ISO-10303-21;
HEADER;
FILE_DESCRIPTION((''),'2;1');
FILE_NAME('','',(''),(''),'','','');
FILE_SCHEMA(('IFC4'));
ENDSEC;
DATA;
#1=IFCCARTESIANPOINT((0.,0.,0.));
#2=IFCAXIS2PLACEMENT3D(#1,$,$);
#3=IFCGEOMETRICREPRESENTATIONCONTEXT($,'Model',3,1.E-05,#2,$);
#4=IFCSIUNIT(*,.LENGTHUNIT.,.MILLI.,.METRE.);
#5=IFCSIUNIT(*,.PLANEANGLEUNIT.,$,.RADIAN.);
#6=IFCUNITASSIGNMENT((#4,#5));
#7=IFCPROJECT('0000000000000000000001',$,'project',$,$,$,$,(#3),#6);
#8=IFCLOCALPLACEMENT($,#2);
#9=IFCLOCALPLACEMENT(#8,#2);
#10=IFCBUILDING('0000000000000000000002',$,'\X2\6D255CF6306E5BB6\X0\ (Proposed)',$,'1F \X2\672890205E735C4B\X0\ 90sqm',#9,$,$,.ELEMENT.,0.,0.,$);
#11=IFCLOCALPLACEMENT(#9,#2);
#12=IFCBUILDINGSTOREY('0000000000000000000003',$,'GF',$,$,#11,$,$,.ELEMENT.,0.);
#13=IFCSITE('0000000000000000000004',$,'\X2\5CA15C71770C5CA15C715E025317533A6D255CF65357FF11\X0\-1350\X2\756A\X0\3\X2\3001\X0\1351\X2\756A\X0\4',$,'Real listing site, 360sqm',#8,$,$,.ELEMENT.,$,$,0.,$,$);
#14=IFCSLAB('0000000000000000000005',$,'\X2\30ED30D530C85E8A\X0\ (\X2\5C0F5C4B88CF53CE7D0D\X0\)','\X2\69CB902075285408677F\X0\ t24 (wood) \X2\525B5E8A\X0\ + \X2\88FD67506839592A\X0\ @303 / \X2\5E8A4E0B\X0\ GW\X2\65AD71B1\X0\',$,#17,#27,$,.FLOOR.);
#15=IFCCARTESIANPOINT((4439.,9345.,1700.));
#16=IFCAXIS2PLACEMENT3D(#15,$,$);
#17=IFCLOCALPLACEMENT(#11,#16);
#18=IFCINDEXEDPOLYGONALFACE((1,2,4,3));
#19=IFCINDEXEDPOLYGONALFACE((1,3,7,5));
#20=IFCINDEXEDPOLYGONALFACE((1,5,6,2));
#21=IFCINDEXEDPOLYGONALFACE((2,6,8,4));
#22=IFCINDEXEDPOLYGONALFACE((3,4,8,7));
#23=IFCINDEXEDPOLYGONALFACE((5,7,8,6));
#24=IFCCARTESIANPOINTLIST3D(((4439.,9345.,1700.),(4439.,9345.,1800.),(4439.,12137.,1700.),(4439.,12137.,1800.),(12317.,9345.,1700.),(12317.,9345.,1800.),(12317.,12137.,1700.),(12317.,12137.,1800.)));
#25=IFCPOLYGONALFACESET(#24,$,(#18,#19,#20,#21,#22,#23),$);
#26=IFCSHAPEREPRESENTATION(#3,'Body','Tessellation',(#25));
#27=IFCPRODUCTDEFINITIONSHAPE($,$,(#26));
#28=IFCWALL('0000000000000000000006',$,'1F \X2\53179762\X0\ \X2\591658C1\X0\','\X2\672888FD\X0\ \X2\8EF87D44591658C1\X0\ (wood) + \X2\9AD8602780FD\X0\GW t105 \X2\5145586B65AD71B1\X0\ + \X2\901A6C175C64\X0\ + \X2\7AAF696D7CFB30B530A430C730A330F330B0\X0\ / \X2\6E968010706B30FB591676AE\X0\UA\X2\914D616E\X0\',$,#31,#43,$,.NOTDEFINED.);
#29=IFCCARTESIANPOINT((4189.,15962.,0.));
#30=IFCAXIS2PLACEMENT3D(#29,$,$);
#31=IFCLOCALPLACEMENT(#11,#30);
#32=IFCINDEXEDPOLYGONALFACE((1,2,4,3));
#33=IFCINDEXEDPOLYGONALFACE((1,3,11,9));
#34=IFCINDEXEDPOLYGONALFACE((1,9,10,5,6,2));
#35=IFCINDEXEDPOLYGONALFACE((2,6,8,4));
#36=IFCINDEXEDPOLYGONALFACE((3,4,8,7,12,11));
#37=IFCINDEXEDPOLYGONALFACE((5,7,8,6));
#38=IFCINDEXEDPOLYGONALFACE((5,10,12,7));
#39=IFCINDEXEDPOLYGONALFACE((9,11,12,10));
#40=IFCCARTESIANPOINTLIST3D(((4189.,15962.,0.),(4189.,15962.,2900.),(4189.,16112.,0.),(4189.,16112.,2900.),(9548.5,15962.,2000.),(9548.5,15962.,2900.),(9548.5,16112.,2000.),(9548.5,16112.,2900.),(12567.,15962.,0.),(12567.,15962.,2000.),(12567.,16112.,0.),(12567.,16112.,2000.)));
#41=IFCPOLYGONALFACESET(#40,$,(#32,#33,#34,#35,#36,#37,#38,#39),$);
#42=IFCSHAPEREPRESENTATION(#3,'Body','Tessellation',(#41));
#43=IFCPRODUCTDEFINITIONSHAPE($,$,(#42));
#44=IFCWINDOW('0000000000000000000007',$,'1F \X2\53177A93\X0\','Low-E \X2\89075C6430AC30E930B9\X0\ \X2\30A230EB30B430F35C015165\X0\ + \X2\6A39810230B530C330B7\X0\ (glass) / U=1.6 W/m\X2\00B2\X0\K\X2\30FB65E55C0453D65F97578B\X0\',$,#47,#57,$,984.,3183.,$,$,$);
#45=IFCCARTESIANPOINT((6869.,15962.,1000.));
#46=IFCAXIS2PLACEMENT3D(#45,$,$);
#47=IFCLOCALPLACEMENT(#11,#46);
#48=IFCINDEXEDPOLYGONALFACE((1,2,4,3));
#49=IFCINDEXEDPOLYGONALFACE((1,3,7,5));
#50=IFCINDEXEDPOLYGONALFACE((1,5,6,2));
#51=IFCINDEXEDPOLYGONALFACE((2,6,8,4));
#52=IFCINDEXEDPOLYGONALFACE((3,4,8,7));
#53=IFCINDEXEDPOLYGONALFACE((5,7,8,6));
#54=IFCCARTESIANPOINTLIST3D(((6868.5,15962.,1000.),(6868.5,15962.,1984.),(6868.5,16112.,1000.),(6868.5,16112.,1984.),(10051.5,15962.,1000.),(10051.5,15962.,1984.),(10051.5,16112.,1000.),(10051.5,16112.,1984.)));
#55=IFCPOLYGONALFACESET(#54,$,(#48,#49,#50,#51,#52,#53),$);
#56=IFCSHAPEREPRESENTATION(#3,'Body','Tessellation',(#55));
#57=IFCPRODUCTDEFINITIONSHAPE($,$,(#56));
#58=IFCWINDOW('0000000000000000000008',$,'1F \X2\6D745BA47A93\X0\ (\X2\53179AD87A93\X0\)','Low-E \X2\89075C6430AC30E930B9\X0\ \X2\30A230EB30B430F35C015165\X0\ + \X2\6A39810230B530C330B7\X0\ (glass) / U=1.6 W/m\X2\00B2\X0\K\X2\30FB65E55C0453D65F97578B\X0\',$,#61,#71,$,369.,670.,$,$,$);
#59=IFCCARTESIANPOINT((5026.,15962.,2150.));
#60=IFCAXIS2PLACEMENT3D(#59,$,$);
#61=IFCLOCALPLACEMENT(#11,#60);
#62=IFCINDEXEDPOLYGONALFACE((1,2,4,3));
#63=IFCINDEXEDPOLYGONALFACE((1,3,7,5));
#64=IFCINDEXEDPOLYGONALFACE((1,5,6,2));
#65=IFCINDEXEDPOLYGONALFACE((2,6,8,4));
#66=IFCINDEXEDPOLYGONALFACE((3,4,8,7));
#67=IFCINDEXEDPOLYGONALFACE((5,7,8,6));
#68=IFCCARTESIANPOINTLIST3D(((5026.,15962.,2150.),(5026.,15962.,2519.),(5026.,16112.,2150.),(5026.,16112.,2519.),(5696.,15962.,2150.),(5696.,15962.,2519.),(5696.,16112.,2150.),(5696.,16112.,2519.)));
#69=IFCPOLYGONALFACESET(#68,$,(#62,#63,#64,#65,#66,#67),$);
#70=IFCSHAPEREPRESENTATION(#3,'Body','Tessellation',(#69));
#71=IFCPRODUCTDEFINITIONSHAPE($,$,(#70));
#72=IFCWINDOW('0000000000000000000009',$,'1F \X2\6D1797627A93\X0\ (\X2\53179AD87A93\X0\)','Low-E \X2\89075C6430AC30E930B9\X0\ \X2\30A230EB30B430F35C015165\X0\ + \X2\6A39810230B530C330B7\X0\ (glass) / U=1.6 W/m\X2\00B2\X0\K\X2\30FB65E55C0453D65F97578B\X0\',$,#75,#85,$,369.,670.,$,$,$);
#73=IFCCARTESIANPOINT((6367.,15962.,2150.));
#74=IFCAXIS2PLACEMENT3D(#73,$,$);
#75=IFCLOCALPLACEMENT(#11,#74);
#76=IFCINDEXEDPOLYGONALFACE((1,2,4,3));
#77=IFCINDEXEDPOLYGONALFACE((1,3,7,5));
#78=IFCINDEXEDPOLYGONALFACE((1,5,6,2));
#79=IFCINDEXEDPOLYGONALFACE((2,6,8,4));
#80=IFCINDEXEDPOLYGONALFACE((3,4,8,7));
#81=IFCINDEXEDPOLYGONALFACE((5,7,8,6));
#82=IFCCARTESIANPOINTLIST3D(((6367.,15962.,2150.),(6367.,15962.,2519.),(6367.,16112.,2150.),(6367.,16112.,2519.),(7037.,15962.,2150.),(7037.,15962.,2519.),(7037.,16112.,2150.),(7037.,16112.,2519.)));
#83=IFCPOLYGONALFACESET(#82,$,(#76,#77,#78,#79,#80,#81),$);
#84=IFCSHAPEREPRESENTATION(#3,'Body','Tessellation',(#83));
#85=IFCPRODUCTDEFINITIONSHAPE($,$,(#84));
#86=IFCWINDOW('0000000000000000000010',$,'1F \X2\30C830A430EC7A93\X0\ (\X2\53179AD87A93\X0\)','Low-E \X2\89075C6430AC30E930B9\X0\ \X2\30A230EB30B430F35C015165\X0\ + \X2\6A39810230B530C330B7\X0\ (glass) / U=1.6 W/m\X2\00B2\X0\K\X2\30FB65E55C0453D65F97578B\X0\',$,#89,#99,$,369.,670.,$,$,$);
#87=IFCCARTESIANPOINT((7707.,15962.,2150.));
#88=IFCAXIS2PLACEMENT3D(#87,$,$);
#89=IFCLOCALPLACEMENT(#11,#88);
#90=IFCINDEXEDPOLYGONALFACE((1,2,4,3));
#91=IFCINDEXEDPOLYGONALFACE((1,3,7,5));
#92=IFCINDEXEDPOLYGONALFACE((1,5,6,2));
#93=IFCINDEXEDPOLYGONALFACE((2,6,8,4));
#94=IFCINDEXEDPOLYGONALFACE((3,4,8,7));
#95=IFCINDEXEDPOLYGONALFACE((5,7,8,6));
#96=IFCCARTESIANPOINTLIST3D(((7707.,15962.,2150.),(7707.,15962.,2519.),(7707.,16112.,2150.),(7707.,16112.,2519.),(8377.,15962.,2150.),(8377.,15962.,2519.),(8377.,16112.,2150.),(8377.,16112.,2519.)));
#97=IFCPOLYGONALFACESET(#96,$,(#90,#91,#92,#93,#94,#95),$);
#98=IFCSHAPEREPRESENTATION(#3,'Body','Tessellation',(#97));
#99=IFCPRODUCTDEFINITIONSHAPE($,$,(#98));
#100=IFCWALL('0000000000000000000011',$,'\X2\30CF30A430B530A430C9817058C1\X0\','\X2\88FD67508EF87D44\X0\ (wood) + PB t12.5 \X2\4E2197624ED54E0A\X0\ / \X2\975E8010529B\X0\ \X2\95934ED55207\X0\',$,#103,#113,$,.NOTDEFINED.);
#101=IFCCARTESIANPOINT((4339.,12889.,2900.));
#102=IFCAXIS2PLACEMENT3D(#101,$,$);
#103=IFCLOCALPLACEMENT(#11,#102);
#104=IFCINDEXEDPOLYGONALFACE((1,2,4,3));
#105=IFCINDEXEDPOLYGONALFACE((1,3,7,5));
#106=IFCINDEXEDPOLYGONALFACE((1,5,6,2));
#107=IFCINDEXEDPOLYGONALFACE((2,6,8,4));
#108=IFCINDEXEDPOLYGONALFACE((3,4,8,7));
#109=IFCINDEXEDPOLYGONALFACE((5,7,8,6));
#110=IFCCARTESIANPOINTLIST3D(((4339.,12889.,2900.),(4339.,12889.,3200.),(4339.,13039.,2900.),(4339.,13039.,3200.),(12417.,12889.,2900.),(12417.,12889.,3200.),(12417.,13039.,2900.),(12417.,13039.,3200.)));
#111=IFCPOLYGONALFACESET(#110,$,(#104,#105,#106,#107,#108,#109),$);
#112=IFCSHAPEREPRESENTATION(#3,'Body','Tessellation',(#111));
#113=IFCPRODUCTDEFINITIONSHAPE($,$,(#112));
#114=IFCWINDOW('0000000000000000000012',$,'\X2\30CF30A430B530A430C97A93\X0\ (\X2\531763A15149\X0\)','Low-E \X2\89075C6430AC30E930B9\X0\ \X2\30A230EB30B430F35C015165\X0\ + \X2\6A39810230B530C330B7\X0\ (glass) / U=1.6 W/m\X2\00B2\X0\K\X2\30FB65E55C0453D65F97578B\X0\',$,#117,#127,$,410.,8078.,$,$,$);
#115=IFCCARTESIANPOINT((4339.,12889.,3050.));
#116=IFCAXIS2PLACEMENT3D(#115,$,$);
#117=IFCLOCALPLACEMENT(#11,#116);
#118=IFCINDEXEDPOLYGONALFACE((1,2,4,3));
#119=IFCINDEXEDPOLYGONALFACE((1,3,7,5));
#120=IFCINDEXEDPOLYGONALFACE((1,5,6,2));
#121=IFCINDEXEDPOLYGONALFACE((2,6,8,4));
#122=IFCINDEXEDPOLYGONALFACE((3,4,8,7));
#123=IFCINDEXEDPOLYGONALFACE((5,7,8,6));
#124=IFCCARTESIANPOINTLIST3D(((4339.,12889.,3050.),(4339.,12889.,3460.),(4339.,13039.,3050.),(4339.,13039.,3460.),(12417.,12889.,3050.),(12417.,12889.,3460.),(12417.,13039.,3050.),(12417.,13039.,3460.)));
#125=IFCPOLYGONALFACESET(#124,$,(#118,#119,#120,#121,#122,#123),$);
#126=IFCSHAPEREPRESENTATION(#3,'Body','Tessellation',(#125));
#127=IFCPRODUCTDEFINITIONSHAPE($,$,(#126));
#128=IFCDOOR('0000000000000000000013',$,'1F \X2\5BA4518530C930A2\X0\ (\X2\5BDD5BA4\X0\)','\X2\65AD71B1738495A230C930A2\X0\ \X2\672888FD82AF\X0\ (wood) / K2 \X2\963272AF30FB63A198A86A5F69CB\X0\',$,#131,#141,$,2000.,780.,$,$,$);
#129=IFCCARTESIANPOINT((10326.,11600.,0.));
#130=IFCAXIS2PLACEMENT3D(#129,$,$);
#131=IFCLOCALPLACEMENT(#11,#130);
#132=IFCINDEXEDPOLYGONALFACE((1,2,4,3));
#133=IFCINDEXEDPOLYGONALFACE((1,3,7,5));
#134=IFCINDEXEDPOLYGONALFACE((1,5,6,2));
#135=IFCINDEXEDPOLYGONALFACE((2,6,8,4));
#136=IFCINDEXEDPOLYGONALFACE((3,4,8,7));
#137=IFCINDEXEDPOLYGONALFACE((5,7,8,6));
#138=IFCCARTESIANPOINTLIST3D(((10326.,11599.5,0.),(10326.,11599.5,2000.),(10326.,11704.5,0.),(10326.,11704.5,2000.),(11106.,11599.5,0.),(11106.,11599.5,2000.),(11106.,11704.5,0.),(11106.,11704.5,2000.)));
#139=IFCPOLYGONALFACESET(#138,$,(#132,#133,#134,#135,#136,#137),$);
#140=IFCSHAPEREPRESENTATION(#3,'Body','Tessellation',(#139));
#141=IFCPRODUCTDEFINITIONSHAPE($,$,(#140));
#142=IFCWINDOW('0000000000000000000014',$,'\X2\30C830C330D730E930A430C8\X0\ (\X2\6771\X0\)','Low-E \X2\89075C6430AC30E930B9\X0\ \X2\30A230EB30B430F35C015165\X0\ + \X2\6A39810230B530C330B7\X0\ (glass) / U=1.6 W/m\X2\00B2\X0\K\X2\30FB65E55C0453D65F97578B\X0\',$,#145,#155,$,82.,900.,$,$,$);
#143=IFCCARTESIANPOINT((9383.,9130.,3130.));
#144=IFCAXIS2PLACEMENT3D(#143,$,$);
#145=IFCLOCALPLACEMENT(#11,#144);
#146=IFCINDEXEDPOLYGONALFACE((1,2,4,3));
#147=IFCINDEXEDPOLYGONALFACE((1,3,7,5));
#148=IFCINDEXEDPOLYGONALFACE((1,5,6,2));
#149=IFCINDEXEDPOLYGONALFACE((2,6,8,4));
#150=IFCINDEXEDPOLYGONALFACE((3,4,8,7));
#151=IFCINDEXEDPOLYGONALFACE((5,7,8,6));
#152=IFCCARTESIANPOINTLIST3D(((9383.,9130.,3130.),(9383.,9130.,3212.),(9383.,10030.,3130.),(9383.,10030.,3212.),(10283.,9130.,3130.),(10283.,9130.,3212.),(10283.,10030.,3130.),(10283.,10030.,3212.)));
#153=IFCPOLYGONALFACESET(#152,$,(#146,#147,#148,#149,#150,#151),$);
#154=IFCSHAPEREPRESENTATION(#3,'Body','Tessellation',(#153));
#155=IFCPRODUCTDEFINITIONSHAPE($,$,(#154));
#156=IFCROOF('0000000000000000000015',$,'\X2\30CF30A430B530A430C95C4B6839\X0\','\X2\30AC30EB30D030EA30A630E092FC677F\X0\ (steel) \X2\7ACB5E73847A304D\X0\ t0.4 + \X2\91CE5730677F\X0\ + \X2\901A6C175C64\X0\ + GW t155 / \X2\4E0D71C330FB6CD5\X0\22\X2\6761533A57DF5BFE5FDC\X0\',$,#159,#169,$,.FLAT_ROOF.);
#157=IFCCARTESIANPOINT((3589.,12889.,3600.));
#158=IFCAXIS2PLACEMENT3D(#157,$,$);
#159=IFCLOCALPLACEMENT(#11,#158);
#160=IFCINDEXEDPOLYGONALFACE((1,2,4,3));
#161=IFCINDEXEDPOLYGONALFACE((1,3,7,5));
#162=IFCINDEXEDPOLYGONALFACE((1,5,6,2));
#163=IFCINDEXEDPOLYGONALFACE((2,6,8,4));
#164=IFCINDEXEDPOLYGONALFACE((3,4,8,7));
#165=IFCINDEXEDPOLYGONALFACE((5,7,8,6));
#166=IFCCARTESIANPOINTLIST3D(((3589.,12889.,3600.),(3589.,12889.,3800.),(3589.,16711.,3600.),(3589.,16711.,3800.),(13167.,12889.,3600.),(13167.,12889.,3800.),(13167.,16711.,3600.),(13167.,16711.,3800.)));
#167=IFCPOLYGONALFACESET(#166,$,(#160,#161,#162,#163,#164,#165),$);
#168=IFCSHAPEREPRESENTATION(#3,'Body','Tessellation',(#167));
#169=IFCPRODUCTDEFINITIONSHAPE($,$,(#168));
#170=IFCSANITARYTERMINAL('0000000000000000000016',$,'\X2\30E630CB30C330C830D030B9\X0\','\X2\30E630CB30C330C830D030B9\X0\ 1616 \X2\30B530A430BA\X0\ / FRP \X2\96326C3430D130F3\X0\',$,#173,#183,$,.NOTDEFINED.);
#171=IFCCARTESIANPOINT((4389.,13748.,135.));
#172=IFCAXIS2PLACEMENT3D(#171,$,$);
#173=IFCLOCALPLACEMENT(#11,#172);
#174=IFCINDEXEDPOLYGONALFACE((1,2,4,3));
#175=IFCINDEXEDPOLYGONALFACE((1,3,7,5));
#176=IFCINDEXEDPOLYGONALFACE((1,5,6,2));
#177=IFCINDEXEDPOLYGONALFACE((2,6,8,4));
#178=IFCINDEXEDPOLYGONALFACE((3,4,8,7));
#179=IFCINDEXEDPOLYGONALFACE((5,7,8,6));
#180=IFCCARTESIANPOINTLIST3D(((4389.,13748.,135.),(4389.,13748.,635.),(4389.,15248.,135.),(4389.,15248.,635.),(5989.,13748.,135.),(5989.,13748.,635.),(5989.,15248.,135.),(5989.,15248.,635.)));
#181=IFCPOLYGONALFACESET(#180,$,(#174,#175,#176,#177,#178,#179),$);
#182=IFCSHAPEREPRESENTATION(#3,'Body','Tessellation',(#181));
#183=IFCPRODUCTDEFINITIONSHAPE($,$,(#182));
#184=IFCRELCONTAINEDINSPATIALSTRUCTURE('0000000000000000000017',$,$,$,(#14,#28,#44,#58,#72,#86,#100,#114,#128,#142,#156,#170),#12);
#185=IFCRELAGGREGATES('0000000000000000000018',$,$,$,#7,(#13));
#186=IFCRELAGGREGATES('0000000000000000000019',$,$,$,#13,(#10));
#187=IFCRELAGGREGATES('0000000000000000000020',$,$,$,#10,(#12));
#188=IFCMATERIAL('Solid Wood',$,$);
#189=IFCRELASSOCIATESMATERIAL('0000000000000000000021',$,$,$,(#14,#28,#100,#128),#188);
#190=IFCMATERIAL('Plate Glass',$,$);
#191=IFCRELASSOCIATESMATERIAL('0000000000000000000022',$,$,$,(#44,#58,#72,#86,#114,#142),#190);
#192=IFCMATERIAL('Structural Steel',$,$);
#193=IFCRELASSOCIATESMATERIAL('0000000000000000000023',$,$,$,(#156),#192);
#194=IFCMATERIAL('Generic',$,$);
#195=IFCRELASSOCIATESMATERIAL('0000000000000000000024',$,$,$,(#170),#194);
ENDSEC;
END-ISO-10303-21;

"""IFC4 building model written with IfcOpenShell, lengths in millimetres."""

from ifc_helpers import new_model, si_unit, frame, frame_2d, origin, place, context, project, spatial, rectangle, extrude, material, element, fill, save


model = new_model("IFC4")

# Units and contexts
model_context = context("Model", 3, precision=1e-05, world=origin())
ifc_project = project(units=[si_unit("LENGTHUNIT", "METRE", prefix="MILLI"), si_unit("PLANEANGLEUNIT", "RADIAN")], contexts=[model_context])

# Site, building, storey
site_placement = place(None, origin())
site = spatial("IfcSite", under=ifc_project, at=site_placement, Name="岡山県岡山市北区津島南１-1350番3、1351番4", ObjectType="Real listing site, 360sqm", CompositionType="ELEMENT", RefElevation=0.0)
building_placement = place(site_placement, origin())
building = spatial("IfcBuilding", under=site, at=building_placement, Name="津島の家 (Proposed)", ObjectType="1F 木造平屋 90sqm", CompositionType="ELEMENT", ElevationOfRefHeight=0.0, ElevationOfTerrain=0.0)
storey_placement = place(building_placement, origin())
storey = spatial("IfcBuildingStorey", under=building, at=storey_placement, Name="GF", CompositionType="ELEMENT", Elevation=0.0)

# Slab
ifc_material_1 = material(Name="Solid Wood")
slab_placement = place(storey_placement, frame((4439.0, 9345.0, 1700.0)))
element("IfcSlab", 1, at=slab_placement, inside=storey, material=ifc_material_1, Name="ロフト床 (小屋裏収納)", Description="構造用合板 t24 (wood) 剛床 + 製材根太 @303 / 床下 GW断熱", PredefinedType="FLOOR", context=model_context, shape_type="SweptSolid", body=[
    extrude(rectangle(XDim=7878.0, YDim=2792.0, at=frame_2d((3939.0, 1396.0))), frame((4439.0, 9345.0, 1700.0)), (0.0, 0.0, 1.0), 100.0),
])

# Wall, openings, windows
wall_1_placement = place(storey_placement, frame((4189.0, 15962.0, 0.0)))
wall_1 = element("IfcWall", 2, at=wall_1_placement, inside=storey, material=ifc_material_1, Name="1F 北面 外壁", Description="木製 軸組外壁 (wood) + 高性能GW t105 充填断熱 + 通気層 + 窯業系サイディング / 準耐火・外皮UA配慮", PredefinedType="NOTDEFINED", context=model_context, shape_type="SweptSolid", body=[
    extrude(rectangle(XDim=8378.0, YDim=150.0, at=frame_2d((4189.0, 75.0))), frame((4189.0, 15962.0, 0.0)), (0.0, 0.0, 1.0), 2900.0),
])
opening_1_placement = place(storey_placement, frame((6869.0, 15962.0, 1000.0)))
opening_1 = element("IfcOpeningElement", 3, at=opening_1_placement, cuts=wall_1, PredefinedType="NOTDEFINED", context=model_context, shape_type="SweptSolid", body=[
    extrude(rectangle(XDim=3183.0, YDim=150.0, at=frame_2d((1591.0, 75.0))), frame((6869.0, 15962.0, 1000.0)), (0.0, 0.0, 1.0), 984.0),
])
opening_2_placement = place(storey_placement, frame((5026.0, 15962.0, 2150.0)))
opening_2 = element("IfcOpeningElement", 4, at=opening_2_placement, cuts=wall_1, PredefinedType="NOTDEFINED", context=model_context, shape_type="SweptSolid", body=[
    extrude(rectangle(XDim=670.0, YDim=150.0, at=frame_2d((335.0, 75.0))), frame((5026.0, 15962.0, 2150.0)), (0.0, 0.0, 1.0), 369.0),
])
opening_3_placement = place(storey_placement, frame((6367.0, 15962.0, 2150.0)))
opening_3 = element("IfcOpeningElement", 5, at=opening_3_placement, cuts=wall_1, PredefinedType="NOTDEFINED", context=model_context, shape_type="SweptSolid", body=[
    extrude(rectangle(XDim=670.0, YDim=150.0, at=frame_2d((335.0, 75.0))), frame((6367.0, 15962.0, 2150.0)), (0.0, 0.0, 1.0), 369.0),
])
opening_4_placement = place(storey_placement, frame((7707.0, 15962.0, 2150.0)))
opening_4 = element("IfcOpeningElement", 6, at=opening_4_placement, cuts=wall_1, PredefinedType="NOTDEFINED", context=model_context, shape_type="SweptSolid", body=[
    extrude(rectangle(XDim=670.0, YDim=150.0, at=frame_2d((335.0, 75.0))), frame((7707.0, 15962.0, 2150.0)), (0.0, 0.0, 1.0), 369.0),
])
ifc_material_2 = material(Name="Plate Glass")
window_1_placement = place(storey_placement, frame((6869.0, 15962.0, 1000.0)))
window_1 = element("IfcWindow", 7, at=window_1_placement, inside=storey, material=ifc_material_2, Name="1F 北窓", Description="Low-E 複層ガラス アルゴン封入 + 樹脂サッシ (glass) / U=1.6 W/m²K・日射取得型", OverallHeight=984.0, OverallWidth=3183.0, context=model_context, shape_type="SweptSolid", body=[
    extrude(rectangle(XDim=3183.0, YDim=150.0, at=frame_2d((1591.0, 75.0))), frame((6869.0, 15962.0, 1000.0)), (0.0, 0.0, 1.0), 984.0),
])
fill(opening_1, window_1)
window_2_placement = place(storey_placement, frame((5026.0, 15962.0, 2150.0)))
window_2 = element("IfcWindow", 8, at=window_2_placement, inside=storey, material=ifc_material_2, Name="1F 浴室窓 (北高窓)", Description="Low-E 複層ガラス アルゴン封入 + 樹脂サッシ (glass) / U=1.6 W/m²K・日射取得型", OverallHeight=369.0, OverallWidth=670.0, context=model_context, shape_type="SweptSolid", body=[
    extrude(rectangle(XDim=670.0, YDim=150.0, at=frame_2d((335.0, 75.0))), frame((5026.0, 15962.0, 2150.0)), (0.0, 0.0, 1.0), 369.0),
])
fill(opening_2, window_2)
window_3_placement = place(storey_placement, frame((6367.0, 15962.0, 2150.0)))
window_3 = element("IfcWindow", 9, at=window_3_placement, inside=storey, material=ifc_material_2, Name="1F 洗面窓 (北高窓)", Description="Low-E 複層ガラス アルゴン封入 + 樹脂サッシ (glass) / U=1.6 W/m²K・日射取得型", OverallHeight=369.0, OverallWidth=670.0, context=model_context, shape_type="SweptSolid", body=[
    extrude(rectangle(XDim=670.0, YDim=150.0, at=frame_2d((335.0, 75.0))), frame((6367.0, 15962.0, 2150.0)), (0.0, 0.0, 1.0), 369.0),
])
fill(opening_3, window_3)
window_4_placement = place(storey_placement, frame((7707.0, 15962.0, 2150.0)))
window_4 = element("IfcWindow", 10, at=window_4_placement, inside=storey, material=ifc_material_2, Name="1F トイレ窓 (北高窓)", Description="Low-E 複層ガラス アルゴン封入 + 樹脂サッシ (glass) / U=1.6 W/m²K・日射取得型", OverallHeight=369.0, OverallWidth=670.0, context=model_context, shape_type="SweptSolid", body=[
    extrude(rectangle(XDim=670.0, YDim=150.0, at=frame_2d((335.0, 75.0))), frame((7707.0, 15962.0, 2150.0)), (0.0, 0.0, 1.0), 369.0),
])
fill(opening_4, window_4)

# Wall, opening, window
wall_2_placement = place(storey_placement, frame((4339.0, 12889.0, 2900.0)))
wall_2 = element("IfcWall", 11, at=wall_2_placement, inside=storey, material=ifc_material_1, Name="ハイサイド腰壁", Description="製材軸組 (wood) + PB t12.5 両面仕上 / 非耐力 間仕切", PredefinedType="NOTDEFINED", context=model_context, shape_type="SweptSolid", body=[
    extrude(rectangle(XDim=8078.0, YDim=150.0, at=frame_2d((4039.0, 75.0))), frame((4339.0, 12889.0, 2900.0)), (0.0, 0.0, 1.0), 700.0),
])
opening_5_placement = place(storey_placement, frame((4339.0, 12889.0, 3050.0)))
opening_5 = element("IfcOpeningElement", 12, at=opening_5_placement, cuts=wall_2, PredefinedType="NOTDEFINED", context=model_context, shape_type="SweptSolid", body=[
    extrude(rectangle(XDim=8078.0, YDim=150.0, at=frame_2d((4039.0, 75.0))), frame((4339.0, 12889.0, 3050.0)), (0.0, 0.0, 1.0), 410.0),
])
window_5_placement = place(storey_placement, frame((4339.0, 12889.0, 3050.0)))
window_5 = element("IfcWindow", 13, at=window_5_placement, inside=storey, material=ifc_material_2, Name="ハイサイド窓 (北採光)", Description="Low-E 複層ガラス アルゴン封入 + 樹脂サッシ (glass) / U=1.6 W/m²K・日射取得型", OverallHeight=410.0, OverallWidth=8078.0, context=model_context, shape_type="SweptSolid", body=[
    extrude(rectangle(XDim=8078.0, YDim=150.0, at=frame_2d((4039.0, 75.0))), frame((4339.0, 12889.0, 3050.0)), (0.0, 0.0, 1.0), 410.0),
])
fill(opening_5, window_5)

# Door
door_1_placement = place(storey_placement, frame((10326.0, 11600.0, 0.0)))
element("IfcDoor", 14, at=door_1_placement, inside=storey, material=ifc_material_1, Name="1F 室内ドア (寝室)", Description="断熱玄関ドア 木製芯 (wood) / K2 防犯・採風機構", OverallHeight=2000.0, OverallWidth=780.0, context=model_context, shape_type="SweptSolid", body=[
    extrude(rectangle(XDim=780.0, YDim=105.0, at=frame_2d((390.0, 52.0))), frame((10326.0, 11600.0, 0.0)), (0.0, 0.0, 1.0), 2000.0),
])

# Window
window_6_placement = place(storey_placement, frame((9383.0, 9130.0, 3130.0)))
element("IfcWindow", 15, at=window_6_placement, inside=storey, material=ifc_material_2, Name="トップライト (東)", Description="Low-E 複層ガラス アルゴン封入 + 樹脂サッシ (glass) / U=1.6 W/m²K・日射取得型", OverallHeight=82.0, OverallWidth=900.0, context=model_context, shape_type="SweptSolid", body=[
    extrude(rectangle(XDim=900.0, YDim=900.0, at=frame_2d((450.0, 450.0))), frame((9383.0, 9130.0, 3130.0)), (0.0, 0.0, 1.0), 82.0),
])

# Roof
ifc_material_3 = material(Name="Structural Steel")
roof_placement = place(storey_placement, frame((3589.0, 12889.0, 3600.0)))
element("IfcRoof", 16, at=roof_placement, inside=storey, material=ifc_material_3, Name="ハイサイド屋根", Description="ガルバリウム鋼板 (steel) 立平葺き t0.4 + 野地板 + 通気層 + GW t155 / 不燃・法22条区域対応", PredefinedType="FLAT_ROOF", context=model_context, shape_type="SweptSolid", body=[
    extrude(rectangle(XDim=9578.0, YDim=3822.0, at=frame_2d((4789.0, 1911.0))), frame((3589.0, 12889.0, 3600.0)), (0.0, 0.0, 1.0), 200.0),
])

# Sanitary terminal
ifc_material_4 = material(Name="Generic")
sanitary_terminal_1_placement = place(storey_placement, frame((4389.0, 13748.0, 135.0)))
element("IfcSanitaryTerminal", 17, at=sanitary_terminal_1_placement, inside=storey, material=ifc_material_4, Name="ユニットバス", Description="ユニットバス 1616 サイズ / FRP 防水パン", PredefinedType="NOTDEFINED", context=model_context, shape_type="SweptSolid", body=[
    extrude(rectangle(XDim=1600.0, YDim=1500.0, at=frame_2d((800.0, 750.0))), frame((4389.0, 13748.0, 135.0)), (0.0, 0.0, 1.0), 500.0),
])

save(model, "model.ifc")
